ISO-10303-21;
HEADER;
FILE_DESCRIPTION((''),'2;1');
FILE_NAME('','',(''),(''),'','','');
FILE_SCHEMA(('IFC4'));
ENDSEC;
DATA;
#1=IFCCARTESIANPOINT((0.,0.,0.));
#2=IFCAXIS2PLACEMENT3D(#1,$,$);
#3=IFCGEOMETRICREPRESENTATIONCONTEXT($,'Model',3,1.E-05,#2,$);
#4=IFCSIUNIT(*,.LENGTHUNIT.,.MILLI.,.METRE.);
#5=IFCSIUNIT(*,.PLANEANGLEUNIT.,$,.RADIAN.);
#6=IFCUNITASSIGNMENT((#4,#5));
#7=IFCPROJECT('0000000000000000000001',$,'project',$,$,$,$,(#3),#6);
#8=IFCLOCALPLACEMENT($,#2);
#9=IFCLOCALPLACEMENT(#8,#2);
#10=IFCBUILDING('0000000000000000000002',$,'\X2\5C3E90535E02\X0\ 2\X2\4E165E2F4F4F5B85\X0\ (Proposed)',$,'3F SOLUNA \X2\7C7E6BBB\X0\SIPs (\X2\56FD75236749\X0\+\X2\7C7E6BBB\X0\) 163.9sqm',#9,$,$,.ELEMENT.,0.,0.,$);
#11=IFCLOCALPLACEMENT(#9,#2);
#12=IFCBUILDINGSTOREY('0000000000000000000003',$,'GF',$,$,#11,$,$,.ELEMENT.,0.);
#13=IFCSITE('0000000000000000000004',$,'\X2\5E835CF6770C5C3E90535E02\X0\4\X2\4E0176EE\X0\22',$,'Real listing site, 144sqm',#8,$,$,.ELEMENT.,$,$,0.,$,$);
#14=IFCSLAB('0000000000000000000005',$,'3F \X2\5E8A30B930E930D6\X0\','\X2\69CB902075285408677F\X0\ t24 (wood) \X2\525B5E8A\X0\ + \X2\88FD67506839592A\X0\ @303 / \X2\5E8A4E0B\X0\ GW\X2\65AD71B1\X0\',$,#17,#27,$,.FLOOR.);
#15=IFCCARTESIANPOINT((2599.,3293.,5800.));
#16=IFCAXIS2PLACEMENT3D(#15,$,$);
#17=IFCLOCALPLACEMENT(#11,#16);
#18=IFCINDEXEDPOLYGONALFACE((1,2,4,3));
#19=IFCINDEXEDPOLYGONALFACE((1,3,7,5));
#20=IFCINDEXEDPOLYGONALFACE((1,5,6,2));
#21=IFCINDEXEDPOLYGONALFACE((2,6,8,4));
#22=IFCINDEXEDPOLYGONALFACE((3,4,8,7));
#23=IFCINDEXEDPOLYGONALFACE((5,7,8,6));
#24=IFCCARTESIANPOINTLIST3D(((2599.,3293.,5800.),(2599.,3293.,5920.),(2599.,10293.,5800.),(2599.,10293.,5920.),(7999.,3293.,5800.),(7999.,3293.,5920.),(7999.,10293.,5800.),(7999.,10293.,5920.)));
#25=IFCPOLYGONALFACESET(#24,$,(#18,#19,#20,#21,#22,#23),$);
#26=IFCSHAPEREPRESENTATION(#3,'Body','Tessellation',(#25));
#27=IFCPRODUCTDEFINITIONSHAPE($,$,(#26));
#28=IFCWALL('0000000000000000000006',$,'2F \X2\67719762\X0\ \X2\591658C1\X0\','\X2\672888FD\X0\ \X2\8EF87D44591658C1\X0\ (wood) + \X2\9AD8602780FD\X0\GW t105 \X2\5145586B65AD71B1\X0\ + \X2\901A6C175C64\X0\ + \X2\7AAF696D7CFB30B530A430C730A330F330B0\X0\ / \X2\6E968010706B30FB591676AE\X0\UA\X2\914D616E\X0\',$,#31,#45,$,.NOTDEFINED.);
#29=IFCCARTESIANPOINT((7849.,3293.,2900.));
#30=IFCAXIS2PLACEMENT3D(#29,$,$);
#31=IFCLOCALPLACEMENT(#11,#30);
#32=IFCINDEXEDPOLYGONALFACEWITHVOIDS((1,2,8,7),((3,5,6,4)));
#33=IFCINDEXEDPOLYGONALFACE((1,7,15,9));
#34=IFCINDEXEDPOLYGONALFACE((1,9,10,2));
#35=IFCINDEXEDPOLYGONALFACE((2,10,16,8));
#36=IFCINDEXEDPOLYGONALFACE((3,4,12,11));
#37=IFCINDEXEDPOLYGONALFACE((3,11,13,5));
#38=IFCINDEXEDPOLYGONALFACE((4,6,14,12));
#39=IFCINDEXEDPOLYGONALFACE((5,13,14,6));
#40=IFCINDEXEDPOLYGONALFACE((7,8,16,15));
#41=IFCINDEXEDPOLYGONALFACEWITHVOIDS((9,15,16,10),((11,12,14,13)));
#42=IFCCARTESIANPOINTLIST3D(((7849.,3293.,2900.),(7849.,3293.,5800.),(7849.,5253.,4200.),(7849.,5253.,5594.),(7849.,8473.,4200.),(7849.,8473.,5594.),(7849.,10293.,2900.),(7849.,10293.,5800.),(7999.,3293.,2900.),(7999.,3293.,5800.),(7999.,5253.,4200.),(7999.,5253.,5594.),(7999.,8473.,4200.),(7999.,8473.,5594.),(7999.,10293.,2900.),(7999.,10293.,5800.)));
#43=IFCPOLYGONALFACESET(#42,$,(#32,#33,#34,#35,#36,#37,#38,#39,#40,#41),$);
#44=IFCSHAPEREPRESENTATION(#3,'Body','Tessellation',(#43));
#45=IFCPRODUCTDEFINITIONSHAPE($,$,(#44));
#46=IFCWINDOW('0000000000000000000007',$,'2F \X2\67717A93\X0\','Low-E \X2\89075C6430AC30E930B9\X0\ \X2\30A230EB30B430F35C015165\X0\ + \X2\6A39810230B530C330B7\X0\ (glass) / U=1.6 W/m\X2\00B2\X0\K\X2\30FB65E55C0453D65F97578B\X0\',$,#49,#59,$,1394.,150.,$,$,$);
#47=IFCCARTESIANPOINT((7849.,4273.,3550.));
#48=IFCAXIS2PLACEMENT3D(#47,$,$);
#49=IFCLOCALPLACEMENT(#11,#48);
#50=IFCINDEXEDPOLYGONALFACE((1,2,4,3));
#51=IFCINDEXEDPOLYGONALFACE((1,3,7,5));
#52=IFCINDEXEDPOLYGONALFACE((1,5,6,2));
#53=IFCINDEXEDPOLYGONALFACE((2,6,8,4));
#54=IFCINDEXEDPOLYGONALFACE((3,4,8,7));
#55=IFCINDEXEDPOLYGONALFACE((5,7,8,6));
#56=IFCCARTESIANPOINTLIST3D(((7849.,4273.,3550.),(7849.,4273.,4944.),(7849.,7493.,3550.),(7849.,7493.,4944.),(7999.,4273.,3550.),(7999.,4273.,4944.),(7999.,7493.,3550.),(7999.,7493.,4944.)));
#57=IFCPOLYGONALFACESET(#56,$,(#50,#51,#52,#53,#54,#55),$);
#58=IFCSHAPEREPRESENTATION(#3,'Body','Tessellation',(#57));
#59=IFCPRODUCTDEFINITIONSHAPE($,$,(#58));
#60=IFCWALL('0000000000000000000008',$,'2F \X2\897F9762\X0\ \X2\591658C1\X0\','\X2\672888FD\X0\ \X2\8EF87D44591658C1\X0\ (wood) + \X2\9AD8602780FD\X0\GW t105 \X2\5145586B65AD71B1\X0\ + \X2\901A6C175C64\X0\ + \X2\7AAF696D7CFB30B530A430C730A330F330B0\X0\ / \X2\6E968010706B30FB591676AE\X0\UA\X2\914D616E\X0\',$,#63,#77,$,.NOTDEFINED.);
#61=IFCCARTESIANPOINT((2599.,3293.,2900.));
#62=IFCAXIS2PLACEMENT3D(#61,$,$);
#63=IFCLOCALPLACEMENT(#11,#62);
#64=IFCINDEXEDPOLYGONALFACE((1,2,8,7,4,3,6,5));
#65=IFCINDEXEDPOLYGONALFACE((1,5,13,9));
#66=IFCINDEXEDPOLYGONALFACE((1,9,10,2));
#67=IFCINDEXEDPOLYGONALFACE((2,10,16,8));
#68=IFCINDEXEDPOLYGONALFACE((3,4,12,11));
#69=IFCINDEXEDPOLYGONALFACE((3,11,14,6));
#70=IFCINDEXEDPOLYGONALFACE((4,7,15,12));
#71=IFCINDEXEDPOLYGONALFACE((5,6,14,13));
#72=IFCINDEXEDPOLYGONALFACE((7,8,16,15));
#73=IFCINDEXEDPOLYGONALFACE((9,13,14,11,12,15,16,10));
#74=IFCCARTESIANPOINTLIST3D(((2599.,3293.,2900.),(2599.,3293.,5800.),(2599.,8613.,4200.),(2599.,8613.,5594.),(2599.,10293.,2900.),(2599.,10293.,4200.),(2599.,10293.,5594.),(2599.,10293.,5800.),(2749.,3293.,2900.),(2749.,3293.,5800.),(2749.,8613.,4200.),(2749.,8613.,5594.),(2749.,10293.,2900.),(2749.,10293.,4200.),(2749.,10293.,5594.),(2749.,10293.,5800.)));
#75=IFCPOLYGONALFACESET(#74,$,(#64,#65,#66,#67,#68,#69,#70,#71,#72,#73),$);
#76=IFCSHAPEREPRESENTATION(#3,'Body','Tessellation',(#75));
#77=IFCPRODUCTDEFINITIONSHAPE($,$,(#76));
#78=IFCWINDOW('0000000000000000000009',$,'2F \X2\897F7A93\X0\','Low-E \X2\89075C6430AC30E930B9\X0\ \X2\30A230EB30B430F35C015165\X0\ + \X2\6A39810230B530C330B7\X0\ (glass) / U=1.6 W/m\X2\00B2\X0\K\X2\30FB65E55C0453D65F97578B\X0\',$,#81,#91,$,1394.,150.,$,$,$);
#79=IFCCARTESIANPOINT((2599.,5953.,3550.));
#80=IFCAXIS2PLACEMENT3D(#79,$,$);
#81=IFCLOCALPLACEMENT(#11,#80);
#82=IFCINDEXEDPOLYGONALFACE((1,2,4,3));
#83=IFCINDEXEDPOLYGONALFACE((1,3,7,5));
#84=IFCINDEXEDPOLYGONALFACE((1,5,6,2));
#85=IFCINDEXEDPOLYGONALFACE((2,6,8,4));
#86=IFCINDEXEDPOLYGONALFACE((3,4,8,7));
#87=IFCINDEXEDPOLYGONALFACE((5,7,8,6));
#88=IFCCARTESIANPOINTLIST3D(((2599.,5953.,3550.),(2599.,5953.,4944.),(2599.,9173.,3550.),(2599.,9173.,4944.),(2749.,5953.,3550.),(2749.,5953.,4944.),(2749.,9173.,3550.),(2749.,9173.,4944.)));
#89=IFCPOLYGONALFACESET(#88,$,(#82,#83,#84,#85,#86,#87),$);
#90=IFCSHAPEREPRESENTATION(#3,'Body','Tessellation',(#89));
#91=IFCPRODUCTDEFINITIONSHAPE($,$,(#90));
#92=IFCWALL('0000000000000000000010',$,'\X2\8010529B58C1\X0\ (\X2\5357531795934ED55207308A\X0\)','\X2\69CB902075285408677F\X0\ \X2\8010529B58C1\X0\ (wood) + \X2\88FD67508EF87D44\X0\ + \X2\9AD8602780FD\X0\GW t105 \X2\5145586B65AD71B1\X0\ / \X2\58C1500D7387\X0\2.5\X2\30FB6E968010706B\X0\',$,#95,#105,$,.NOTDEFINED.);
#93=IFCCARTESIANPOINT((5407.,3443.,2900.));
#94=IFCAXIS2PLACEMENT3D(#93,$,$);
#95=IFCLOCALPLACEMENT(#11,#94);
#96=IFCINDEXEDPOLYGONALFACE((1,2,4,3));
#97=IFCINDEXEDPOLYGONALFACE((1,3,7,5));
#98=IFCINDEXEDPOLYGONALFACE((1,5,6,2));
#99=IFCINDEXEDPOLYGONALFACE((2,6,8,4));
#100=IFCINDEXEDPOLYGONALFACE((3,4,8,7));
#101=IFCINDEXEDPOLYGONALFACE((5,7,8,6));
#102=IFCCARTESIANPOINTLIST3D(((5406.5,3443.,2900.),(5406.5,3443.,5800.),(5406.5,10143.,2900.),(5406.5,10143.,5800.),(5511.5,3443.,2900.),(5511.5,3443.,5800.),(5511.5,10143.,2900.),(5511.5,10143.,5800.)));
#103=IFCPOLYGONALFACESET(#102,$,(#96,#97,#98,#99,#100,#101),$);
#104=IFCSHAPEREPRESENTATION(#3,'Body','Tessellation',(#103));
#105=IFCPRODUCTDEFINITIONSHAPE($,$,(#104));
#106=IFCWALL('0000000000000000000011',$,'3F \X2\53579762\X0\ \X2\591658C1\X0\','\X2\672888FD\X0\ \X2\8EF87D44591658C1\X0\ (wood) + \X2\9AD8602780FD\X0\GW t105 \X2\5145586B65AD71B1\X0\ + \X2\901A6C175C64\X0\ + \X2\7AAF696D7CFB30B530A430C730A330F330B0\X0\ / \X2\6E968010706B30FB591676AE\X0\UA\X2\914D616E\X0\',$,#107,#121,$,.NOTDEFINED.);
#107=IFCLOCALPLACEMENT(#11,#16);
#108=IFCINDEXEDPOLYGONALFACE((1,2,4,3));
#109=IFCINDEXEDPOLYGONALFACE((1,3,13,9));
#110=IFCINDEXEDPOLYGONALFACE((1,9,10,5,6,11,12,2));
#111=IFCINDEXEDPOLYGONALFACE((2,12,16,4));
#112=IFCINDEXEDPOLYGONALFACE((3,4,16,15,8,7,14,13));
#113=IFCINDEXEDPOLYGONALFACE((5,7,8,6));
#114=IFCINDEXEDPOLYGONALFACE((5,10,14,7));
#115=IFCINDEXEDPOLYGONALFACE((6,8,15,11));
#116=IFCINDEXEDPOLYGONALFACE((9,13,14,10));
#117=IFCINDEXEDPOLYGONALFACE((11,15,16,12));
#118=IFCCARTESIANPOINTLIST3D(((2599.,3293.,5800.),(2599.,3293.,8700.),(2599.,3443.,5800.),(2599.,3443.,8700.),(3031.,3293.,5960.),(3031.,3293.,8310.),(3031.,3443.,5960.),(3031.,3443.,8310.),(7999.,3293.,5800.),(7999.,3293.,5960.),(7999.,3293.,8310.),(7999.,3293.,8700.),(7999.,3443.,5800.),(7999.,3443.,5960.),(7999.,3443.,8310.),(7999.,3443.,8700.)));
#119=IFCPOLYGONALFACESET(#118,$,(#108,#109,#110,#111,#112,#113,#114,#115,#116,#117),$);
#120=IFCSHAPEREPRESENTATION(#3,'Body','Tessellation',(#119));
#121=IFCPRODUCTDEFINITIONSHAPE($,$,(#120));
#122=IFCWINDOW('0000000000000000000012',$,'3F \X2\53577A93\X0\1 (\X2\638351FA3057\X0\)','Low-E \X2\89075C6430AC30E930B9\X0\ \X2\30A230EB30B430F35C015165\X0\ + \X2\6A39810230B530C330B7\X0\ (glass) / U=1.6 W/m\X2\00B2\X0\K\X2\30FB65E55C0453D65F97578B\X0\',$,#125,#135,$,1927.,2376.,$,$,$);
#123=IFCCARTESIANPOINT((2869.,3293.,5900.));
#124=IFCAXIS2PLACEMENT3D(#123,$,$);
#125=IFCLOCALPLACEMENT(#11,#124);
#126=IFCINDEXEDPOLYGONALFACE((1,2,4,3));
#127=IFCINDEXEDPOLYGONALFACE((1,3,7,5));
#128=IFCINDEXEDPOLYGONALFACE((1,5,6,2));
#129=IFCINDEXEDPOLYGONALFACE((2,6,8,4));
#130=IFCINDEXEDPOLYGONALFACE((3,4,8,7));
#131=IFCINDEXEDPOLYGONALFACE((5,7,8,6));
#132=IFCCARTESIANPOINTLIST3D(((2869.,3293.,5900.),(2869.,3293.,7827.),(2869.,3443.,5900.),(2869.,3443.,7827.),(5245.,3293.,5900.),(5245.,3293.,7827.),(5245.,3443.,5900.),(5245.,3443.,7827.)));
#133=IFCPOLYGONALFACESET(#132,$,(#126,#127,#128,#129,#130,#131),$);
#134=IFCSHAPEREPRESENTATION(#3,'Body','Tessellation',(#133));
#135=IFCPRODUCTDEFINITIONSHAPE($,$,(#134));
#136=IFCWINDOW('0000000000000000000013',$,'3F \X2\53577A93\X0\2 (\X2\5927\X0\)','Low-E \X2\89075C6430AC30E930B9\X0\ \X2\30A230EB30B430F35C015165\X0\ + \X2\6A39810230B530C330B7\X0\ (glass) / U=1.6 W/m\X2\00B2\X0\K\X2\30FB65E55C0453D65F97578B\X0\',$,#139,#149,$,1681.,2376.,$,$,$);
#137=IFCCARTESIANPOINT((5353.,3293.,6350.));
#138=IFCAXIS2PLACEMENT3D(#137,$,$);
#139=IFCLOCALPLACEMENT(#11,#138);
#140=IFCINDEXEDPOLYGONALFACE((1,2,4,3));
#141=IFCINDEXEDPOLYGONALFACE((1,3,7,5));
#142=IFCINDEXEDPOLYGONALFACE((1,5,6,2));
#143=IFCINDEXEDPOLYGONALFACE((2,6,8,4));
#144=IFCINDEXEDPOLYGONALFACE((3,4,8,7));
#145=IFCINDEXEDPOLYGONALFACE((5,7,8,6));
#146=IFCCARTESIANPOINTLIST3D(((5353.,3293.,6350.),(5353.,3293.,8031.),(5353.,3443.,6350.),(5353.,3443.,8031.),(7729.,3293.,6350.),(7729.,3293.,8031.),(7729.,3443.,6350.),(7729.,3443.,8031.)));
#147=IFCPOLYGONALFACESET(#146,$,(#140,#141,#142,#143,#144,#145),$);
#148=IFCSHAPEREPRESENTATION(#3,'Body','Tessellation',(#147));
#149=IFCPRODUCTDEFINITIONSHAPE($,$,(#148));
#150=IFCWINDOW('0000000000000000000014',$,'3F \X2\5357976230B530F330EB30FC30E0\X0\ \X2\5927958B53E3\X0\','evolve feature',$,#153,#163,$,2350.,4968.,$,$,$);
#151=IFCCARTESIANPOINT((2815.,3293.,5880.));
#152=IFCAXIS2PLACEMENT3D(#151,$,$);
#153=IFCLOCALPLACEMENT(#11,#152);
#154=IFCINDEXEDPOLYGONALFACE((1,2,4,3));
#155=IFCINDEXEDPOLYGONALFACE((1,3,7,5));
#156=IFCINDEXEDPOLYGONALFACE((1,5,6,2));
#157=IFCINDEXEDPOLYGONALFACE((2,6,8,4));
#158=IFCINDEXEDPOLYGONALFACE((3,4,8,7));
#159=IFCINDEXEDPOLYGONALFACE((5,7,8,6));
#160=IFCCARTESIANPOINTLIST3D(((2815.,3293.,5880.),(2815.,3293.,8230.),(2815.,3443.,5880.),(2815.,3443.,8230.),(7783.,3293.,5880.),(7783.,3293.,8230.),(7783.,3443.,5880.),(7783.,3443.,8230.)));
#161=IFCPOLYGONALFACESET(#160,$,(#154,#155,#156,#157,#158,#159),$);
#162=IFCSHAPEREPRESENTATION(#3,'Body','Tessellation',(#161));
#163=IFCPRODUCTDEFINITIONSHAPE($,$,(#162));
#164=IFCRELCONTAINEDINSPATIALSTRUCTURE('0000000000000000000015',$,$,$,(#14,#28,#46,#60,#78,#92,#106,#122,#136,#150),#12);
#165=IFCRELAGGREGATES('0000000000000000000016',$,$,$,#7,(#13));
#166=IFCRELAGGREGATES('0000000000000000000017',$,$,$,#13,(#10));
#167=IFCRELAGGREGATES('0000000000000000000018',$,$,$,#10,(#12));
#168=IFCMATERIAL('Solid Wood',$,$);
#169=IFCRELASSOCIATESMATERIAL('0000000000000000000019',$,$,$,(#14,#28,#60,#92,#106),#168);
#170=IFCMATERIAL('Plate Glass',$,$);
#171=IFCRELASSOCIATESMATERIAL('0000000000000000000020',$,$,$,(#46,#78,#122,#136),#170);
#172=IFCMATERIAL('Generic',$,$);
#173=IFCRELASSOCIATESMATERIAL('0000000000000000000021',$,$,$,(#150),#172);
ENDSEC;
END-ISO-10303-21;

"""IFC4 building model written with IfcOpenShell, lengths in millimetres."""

from ifc_helpers import new_model, si_unit, frame, frame_2d, origin, place, context, project, spatial, rectangle, extrude, material, element, fill, save


model = new_model("IFC4")

# Units and contexts
model_context = context("Model", 3, precision=1e-05, world=origin())
ifc_project = project(units=[si_unit("LENGTHUNIT", "METRE", prefix="MILLI"), si_unit("PLANEANGLEUNIT", "RADIAN")], contexts=[model_context])

# Site, building, storey
site_placement = place(None, origin())
site = spatial("IfcSite", under=ifc_project, at=site_placement, Name="広島県尾道市4丁目22", ObjectType="Real listing site, 144sqm", CompositionType="ELEMENT", RefElevation=0.0)
building_placement = place(site_placement, origin())
building = spatial("IfcBuilding", under=site, at=building_placement, Name="尾道市 2世帯住宅 (Proposed)", ObjectType="3F SOLUNA 籾殻SIPs (国産杉+籾殻) 163.9sqm", CompositionType="ELEMENT", ElevationOfRefHeight=0.0, ElevationOfTerrain=0.0)
storey_placement = place(building_placement, origin())
storey = spatial("IfcBuildingStorey", under=building, at=storey_placement, Name="GF", CompositionType="ELEMENT", Elevation=0.0)

# Slab
ifc_material_1 = material(Name="Solid Wood")
slab_placement = place(storey_placement, frame((2599.0, 3293.0, 5800.0)))
element("IfcSlab", 1, at=slab_placement, inside=storey, material=ifc_material_1, Name="3F 床スラブ", Description="構造用合板 t24 (wood) 剛床 + 製材根太 @303 / 床下 GW断熱", PredefinedType="FLOOR", context=model_context, shape_type="SweptSolid", body=[
    extrude(rectangle(XDim=5400.0, YDim=7000.0, at=frame_2d((2700.0, 3500.0))), frame((2599.0, 3293.0, 5800.0)), (0.0, 0.0, 1.0), 120.0),
])

# Walls, openings, windows
wall_1_placement = place(storey_placement, frame((7849.0, 3293.0, 2900.0)))
wall_1 = element("IfcWall", 2, at=wall_1_placement, inside=storey, material=ifc_material_1, Name="2F 東面 外壁", Description="木製 軸組外壁 (wood) + 高性能GW t105 充填断熱 + 通気層 + 窯業系サイディング / 準耐火・外皮UA配慮", PredefinedType="NOTDEFINED", context=model_context, shape_type="SweptSolid", body=[
    extrude(rectangle(XDim=150.0, YDim=7000.0, at=frame_2d((75.0, 3500.0))), frame((7849.0, 3293.0, 2900.0)), (0.0, 0.0, 1.0), 2900.0),
])
opening_1_placement = place(storey_placement, frame((7849.0, 4273.0, 3550.0)))
opening_1 = element("IfcOpeningElement", 3, at=opening_1_placement, cuts=wall_1, PredefinedType="NOTDEFINED", context=model_context, shape_type="SweptSolid", body=[
    extrude(rectangle(XDim=150.0, YDim=3220.0, at=frame_2d((75.0, 1610.0))), frame((7849.0, 4273.0, 3550.0)), (0.0, 0.0, 1.0), 1394.0),
])
ifc_material_2 = material(Name="Plate Glass")
window_1_placement = place(storey_placement, frame((7849.0, 4273.0, 3550.0)))
window_1 = element("IfcWindow", 4, at=window_1_placement, inside=storey, material=ifc_material_2, Name="2F 東窓", Description="Low-E 複層ガラス アルゴン封入 + 樹脂サッシ (glass) / U=1.6 W/m²K・日射取得型", OverallHeight=1394.0, OverallWidth=150.0, context=model_context, shape_type="SweptSolid", body=[
    extrude(rectangle(XDim=150.0, YDim=3220.0, at=frame_2d((75.0, 1610.0))), frame((7849.0, 4273.0, 3550.0)), (0.0, 0.0, 1.0), 1394.0),
])
fill(opening_1, window_1)
wall_2_placement = place(storey_placement, frame((2599.0, 3293.0, 2900.0)))
wall_2 = element("IfcWall", 5, at=wall_2_placement, inside=storey, material=ifc_material_1, Name="2F 西面 外壁", Description="木製 軸組外壁 (wood) + 高性能GW t105 充填断熱 + 通気層 + 窯業系サイディング / 準耐火・外皮UA配慮", PredefinedType="NOTDEFINED", context=model_context, shape_type="SweptSolid", body=[
    extrude(rectangle(XDim=150.0, YDim=7000.0, at=frame_2d((75.0, 3500.0))), frame((2599.0, 3293.0, 2900.0)), (0.0, 0.0, 1.0), 2900.0),
])
opening_2_placement = place(storey_placement, frame((2599.0, 5953.0, 3550.0)))
opening_2 = element("IfcOpeningElement", 6, at=opening_2_placement, cuts=wall_2, PredefinedType="NOTDEFINED", context=model_context, shape_type="SweptSolid", body=[
    extrude(rectangle(XDim=150.0, YDim=3220.0, at=frame_2d((75.0, 1610.0))), frame((2599.0, 5953.0, 3550.0)), (0.0, 0.0, 1.0), 1394.0),
])
window_2_placement = place(storey_placement, frame((2599.0, 5953.0, 3550.0)))
window_2 = element("IfcWindow", 7, at=window_2_placement, inside=storey, material=ifc_material_2, Name="2F 西窓", Description="Low-E 複層ガラス アルゴン封入 + 樹脂サッシ (glass) / U=1.6 W/m²K・日射取得型", OverallHeight=1394.0, OverallWidth=150.0, context=model_context, shape_type="SweptSolid", body=[
    extrude(rectangle(XDim=150.0, YDim=3220.0, at=frame_2d((75.0, 1610.0))), frame((2599.0, 5953.0, 3550.0)), (0.0, 0.0, 1.0), 1394.0),
])
fill(opening_2, window_2)

# Wall
wall_3_placement = place(storey_placement, frame((5407.0, 3443.0, 2900.0)))
element("IfcWall", 8, at=wall_3_placement, inside=storey, material=ifc_material_1, Name="耐力壁 (南北間仕切り)", Description="構造用合板 耐力壁 (wood) + 製材軸組 + 高性能GW t105 充填断熱 / 壁倍率2.5・準耐火", PredefinedType="NOTDEFINED", context=model_context, shape_type="SweptSolid", body=[
    extrude(rectangle(XDim=105.0, YDim=6700.0, at=frame_2d((52.0, 3350.0))), frame((5407.0, 3443.0, 2900.0)), (0.0, 0.0, 1.0), 2900.0),
])

# Wall, openings, windows
wall_4_placement = place(storey_placement, frame((2599.0, 3293.0, 5800.0)))
wall_4 = element("IfcWall", 9, at=wall_4_placement, inside=storey, material=ifc_material_1, Name="3F 南面 外壁", Description="木製 軸組外壁 (wood) + 高性能GW t105 充填断熱 + 通気層 + 窯業系サイディング / 準耐火・外皮UA配慮", PredefinedType="NOTDEFINED", context=model_context, shape_type="SweptSolid", body=[
    extrude(rectangle(XDim=5400.0, YDim=150.0, at=frame_2d((2700.0, 75.0))), frame((2599.0, 3293.0, 5800.0)), (0.0, 0.0, 1.0), 2900.0),
])
opening_3_placement = place(storey_placement, frame((2869.0, 3293.0, 5900.0)))
opening_3 = element("IfcOpeningElement", 10, at=opening_3_placement, cuts=wall_4, PredefinedType="NOTDEFINED", context=model_context, shape_type="SweptSolid", body=[
    extrude(rectangle(XDim=2376.0, YDim=150.0, at=frame_2d((1188.0, 75.0))), frame((2869.0, 3293.0, 5900.0)), (0.0, 0.0, 1.0), 1927.0),
])
opening_4_placement = place(storey_placement, frame((5353.0, 3293.0, 6350.0)))
opening_4 = element("IfcOpeningElement", 11, at=opening_4_placement, cuts=wall_4, PredefinedType="NOTDEFINED", context=model_context, shape_type="SweptSolid", body=[
    extrude(rectangle(XDim=2376.0, YDim=150.0, at=frame_2d((1188.0, 75.0))), frame((5353.0, 3293.0, 6350.0)), (0.0, 0.0, 1.0), 1681.0),
])
opening_5_placement = place(storey_placement, frame((2815.0, 3293.0, 5880.0)))
opening_5 = element("IfcOpeningElement", 12, at=opening_5_placement, cuts=wall_4, PredefinedType="NOTDEFINED", context=model_context, shape_type="SweptSolid", body=[
    extrude(rectangle(XDim=4968.0, YDim=150.0, at=frame_2d((2484.0, 75.0))), frame((2815.0, 3293.0, 5880.0)), (0.0, 0.0, 1.0), 2350.0),
])
window_3_placement = place(storey_placement, frame((2869.0, 3293.0, 5900.0)))
window_3 = element("IfcWindow", 13, at=window_3_placement, inside=storey, material=ifc_material_2, Name="3F 南窓1 (掃出し)", Description="Low-E 複層ガラス アルゴン封入 + 樹脂サッシ (glass) / U=1.6 W/m²K・日射取得型", OverallHeight=1927.0, OverallWidth=2376.0, context=model_context, shape_type="SweptSolid", body=[
    extrude(rectangle(XDim=2376.0, YDim=150.0, at=frame_2d((1188.0, 75.0))), frame((2869.0, 3293.0, 5900.0)), (0.0, 0.0, 1.0), 1927.0),
])
fill(opening_3, window_3)
window_4_placement = place(storey_placement, frame((5353.0, 3293.0, 6350.0)))
window_4 = element("IfcWindow", 14, at=window_4_placement, inside=storey, material=ifc_material_2, Name="3F 南窓2 (大)", Description="Low-E 複層ガラス アルゴン封入 + 樹脂サッシ (glass) / U=1.6 W/m²K・日射取得型", OverallHeight=1681.0, OverallWidth=2376.0, context=model_context, shape_type="SweptSolid", body=[
    extrude(rectangle(XDim=2376.0, YDim=150.0, at=frame_2d((1188.0, 75.0))), frame((5353.0, 3293.0, 6350.0)), (0.0, 0.0, 1.0), 1681.0),
])
fill(opening_4, window_4)
ifc_material_3 = material(Name="Generic")
window_5_placement = place(storey_placement, frame((2815.0, 3293.0, 5880.0)))
window_5 = element("IfcWindow", 15, at=window_5_placement, inside=storey, material=ifc_material_3, Name="3F 南面サンルーム 大開口", Description="evolve feature", OverallHeight=2350.0, OverallWidth=4968.0, context=model_context, shape_type="SweptSolid", body=[
    extrude(rectangle(XDim=4968.0, YDim=150.0, at=frame_2d((2484.0, 75.0))), frame((2815.0, 3293.0, 5880.0)), (0.0, 0.0, 1.0), 2350.0),
])
fill(opening_5, window_5)

save(model, "model.ifc")
